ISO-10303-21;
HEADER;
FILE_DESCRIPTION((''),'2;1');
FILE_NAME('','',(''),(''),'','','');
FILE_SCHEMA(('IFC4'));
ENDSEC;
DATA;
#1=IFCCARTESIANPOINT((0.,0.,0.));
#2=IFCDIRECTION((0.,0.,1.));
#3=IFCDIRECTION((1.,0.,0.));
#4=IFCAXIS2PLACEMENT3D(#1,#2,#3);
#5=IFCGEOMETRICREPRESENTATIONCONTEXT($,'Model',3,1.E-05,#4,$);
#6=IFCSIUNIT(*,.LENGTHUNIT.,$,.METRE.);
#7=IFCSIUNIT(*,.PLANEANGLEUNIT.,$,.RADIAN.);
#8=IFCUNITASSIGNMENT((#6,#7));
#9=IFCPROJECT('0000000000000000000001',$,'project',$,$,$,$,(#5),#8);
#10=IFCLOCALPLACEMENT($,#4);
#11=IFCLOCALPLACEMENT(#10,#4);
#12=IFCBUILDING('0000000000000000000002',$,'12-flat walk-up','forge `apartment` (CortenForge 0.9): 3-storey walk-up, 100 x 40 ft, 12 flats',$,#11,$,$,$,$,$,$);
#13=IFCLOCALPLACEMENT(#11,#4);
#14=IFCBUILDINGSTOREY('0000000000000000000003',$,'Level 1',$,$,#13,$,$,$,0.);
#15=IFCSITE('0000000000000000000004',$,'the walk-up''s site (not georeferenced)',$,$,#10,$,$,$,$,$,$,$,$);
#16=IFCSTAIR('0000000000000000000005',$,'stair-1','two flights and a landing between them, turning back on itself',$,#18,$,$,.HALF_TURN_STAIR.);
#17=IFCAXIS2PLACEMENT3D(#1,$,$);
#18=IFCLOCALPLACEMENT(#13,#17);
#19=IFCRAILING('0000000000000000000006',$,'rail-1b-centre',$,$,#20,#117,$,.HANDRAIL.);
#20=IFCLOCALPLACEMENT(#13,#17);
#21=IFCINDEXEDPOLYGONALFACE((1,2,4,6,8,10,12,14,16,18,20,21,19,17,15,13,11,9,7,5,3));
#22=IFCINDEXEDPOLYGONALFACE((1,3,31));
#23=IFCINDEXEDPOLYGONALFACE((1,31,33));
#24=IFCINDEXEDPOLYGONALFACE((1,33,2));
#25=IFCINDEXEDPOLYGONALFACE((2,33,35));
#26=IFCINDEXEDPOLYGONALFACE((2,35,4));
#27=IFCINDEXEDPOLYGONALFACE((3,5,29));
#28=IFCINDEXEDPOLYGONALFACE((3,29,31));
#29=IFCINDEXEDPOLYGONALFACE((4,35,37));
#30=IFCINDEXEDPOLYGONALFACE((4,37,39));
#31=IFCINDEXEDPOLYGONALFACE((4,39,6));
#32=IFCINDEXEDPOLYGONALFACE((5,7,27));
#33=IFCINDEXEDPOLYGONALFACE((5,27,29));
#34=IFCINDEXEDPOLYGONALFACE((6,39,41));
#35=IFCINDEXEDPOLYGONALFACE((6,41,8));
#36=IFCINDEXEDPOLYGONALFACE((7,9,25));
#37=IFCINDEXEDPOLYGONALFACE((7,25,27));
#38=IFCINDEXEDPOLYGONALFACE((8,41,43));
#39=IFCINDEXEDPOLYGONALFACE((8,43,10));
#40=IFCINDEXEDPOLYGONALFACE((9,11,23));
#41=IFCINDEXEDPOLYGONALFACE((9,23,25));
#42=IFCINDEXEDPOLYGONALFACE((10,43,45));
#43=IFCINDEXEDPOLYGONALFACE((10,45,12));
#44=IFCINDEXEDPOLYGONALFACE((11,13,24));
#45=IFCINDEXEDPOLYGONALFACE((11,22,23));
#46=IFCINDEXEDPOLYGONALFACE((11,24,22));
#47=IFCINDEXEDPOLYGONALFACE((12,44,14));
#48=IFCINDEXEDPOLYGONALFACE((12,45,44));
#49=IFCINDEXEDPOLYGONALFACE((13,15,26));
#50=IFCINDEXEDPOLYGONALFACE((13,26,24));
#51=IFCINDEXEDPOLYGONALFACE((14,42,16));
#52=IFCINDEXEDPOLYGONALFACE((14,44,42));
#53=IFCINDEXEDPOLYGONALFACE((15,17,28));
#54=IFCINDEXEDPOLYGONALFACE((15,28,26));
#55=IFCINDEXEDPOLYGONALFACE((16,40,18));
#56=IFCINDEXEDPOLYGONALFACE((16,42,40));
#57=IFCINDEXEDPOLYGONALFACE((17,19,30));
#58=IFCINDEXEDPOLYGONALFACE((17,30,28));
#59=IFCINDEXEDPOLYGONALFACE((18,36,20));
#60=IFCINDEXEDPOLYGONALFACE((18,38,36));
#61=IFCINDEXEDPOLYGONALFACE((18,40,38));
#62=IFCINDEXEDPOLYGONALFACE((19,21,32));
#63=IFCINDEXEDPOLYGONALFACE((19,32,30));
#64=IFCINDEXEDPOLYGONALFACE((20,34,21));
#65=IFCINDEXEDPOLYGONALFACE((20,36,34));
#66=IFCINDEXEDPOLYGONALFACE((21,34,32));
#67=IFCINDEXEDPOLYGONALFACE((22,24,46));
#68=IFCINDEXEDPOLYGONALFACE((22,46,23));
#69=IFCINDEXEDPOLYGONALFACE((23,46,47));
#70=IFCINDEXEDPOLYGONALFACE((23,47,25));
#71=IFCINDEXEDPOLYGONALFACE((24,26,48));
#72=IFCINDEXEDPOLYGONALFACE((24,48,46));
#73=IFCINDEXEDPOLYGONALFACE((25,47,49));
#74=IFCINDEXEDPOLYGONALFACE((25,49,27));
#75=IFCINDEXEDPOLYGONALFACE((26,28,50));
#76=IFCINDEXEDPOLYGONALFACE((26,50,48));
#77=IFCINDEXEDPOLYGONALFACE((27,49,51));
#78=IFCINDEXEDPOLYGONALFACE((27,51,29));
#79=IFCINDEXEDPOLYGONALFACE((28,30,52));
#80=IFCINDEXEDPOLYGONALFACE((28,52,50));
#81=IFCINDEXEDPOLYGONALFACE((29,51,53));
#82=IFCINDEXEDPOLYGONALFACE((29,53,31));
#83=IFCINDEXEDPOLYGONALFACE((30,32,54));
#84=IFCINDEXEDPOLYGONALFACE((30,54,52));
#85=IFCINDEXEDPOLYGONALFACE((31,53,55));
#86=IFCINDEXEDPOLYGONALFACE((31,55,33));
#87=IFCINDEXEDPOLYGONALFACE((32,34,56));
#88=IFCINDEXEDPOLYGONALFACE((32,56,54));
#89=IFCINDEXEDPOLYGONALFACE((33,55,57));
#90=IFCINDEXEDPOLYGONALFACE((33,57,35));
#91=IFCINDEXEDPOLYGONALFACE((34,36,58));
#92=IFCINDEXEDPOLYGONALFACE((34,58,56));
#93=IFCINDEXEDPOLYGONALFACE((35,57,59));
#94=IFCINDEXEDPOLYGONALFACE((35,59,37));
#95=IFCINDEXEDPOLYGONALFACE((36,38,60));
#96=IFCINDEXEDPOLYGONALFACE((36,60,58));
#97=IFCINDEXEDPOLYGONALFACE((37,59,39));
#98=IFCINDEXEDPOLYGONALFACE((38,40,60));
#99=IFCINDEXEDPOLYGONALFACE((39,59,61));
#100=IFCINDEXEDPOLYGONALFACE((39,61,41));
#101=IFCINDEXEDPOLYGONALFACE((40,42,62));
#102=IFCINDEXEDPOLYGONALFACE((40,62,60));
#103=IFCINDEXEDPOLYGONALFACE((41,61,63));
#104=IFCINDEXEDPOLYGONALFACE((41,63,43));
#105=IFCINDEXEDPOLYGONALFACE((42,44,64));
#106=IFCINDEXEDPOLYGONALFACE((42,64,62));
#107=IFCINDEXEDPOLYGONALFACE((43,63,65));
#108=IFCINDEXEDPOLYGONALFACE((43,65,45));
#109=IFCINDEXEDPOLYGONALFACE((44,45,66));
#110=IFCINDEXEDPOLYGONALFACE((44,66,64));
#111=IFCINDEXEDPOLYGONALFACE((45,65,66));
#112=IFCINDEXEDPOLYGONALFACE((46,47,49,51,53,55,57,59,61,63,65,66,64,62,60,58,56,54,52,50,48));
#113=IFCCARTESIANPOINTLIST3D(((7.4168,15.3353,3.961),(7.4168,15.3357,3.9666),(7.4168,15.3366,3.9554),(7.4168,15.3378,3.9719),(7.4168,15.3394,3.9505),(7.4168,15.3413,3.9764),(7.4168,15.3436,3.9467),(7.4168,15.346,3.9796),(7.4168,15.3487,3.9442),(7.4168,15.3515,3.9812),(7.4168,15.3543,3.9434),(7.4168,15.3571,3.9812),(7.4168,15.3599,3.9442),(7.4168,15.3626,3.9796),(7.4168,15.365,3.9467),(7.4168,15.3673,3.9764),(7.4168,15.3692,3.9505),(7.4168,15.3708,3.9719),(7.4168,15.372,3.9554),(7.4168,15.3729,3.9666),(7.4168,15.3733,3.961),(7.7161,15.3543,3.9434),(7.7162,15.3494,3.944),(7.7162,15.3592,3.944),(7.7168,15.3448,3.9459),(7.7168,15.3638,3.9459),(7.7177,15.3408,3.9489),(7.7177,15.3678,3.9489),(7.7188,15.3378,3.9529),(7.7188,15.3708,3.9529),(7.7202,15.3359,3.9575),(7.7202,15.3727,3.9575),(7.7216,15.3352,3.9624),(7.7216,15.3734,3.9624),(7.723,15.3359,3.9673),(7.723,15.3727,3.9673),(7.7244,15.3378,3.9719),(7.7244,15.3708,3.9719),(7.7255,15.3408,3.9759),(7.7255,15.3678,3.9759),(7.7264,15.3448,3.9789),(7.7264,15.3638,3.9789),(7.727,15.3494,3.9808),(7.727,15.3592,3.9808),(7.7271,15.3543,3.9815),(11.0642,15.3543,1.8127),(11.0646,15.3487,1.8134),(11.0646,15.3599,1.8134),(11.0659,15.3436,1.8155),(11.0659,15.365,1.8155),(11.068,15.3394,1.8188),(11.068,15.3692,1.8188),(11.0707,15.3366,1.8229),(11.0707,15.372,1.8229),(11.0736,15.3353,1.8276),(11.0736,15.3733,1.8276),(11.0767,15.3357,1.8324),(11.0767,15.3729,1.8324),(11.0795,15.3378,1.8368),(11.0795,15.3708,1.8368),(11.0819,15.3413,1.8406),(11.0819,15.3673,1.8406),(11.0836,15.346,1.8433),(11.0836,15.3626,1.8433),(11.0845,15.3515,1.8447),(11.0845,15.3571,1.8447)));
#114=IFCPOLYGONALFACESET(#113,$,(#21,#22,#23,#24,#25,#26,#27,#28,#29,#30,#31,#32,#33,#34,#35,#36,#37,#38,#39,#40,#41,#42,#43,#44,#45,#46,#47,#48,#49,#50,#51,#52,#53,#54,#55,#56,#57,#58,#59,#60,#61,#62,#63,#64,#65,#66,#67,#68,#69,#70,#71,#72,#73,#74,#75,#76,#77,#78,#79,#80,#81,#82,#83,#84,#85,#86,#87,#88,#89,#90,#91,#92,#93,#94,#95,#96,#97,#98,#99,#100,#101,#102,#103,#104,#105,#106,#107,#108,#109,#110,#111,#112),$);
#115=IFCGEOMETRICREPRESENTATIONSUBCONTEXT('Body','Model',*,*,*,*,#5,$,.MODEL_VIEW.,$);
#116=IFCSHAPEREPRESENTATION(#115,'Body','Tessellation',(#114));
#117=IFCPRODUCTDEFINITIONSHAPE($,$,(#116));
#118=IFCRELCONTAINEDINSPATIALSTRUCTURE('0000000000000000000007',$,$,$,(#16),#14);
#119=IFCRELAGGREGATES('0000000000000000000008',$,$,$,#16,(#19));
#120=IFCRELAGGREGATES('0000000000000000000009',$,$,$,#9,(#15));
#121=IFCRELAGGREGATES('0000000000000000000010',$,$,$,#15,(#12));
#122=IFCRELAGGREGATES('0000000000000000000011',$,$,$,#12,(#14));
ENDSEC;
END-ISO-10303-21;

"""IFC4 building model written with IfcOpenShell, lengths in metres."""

from ifc_helpers import new_model, entity, si_unit, frame, origin_with_axes, place, context, subcontext, project, spatial, element, aggregate, save


model = new_model("IFC4")

# Units and contexts
model_context = context("Model", 3, precision=1e-05, world=origin_with_axes())
body_context = subcontext(model_context, "Body", "Model", "MODEL_VIEW")
ifc_project = project(units=[si_unit("LENGTHUNIT", "METRE"), si_unit("PLANEANGLEUNIT", "RADIAN")], contexts=[model_context])

# Site, building, storey
site_placement = place(None, origin_with_axes())
site = spatial("IfcSite", under=ifc_project, at=site_placement, Name="the walk-up's site (not georeferenced)")
building_placement = place(site_placement, origin_with_axes())
building = spatial("IfcBuilding", under=site, at=building_placement, Name="12-flat walk-up", Description="forge `apartment` (CortenForge 0.9): 3-storey walk-up, 100 x 40 ft, 12 flats")
storey_placement = place(building_placement, origin_with_axes())
storey = spatial("IfcBuildingStorey", under=building, at=storey_placement, Name="Level 1", Elevation=0.0)

# Stair, railing
stair_placement = place(storey_placement, origin_with_axes())
stair = element("IfcStair", 1, at=stair_placement, inside=storey, Name="stair-1", Description="two flights and a landing between them, turning back on itself", PredefinedType="HALF_TURN_STAIR")
railing_1_placement = place(stair_placement, frame((11.0744, 15.3543, 1.8288), z_axis=(0.0, 0.0, 1.0), x_axis=(1.0, 0.0, 0.0)))
railing_1 = element("IfcRailing", 2, at=railing_1_placement, Name="rail-1b-centre", PredefinedType="HANDRAIL", context=body_context, shape_type="AdvancedSweptSolid", body=[
    entity("IfcSweptDiskSolid", entity("IfcPolyline", [entity("IfcCartesianPoint", [0.0, 0.0, 0.0]), entity("IfcCartesianPoint", [-3.3528, 0.0, 2.1336]), entity("IfcCartesianPoint", [-3.6576, 0.0, 2.1336])]), 0.0191),
])
aggregate(stair, [railing_1])

save(model, "model.ifc")
